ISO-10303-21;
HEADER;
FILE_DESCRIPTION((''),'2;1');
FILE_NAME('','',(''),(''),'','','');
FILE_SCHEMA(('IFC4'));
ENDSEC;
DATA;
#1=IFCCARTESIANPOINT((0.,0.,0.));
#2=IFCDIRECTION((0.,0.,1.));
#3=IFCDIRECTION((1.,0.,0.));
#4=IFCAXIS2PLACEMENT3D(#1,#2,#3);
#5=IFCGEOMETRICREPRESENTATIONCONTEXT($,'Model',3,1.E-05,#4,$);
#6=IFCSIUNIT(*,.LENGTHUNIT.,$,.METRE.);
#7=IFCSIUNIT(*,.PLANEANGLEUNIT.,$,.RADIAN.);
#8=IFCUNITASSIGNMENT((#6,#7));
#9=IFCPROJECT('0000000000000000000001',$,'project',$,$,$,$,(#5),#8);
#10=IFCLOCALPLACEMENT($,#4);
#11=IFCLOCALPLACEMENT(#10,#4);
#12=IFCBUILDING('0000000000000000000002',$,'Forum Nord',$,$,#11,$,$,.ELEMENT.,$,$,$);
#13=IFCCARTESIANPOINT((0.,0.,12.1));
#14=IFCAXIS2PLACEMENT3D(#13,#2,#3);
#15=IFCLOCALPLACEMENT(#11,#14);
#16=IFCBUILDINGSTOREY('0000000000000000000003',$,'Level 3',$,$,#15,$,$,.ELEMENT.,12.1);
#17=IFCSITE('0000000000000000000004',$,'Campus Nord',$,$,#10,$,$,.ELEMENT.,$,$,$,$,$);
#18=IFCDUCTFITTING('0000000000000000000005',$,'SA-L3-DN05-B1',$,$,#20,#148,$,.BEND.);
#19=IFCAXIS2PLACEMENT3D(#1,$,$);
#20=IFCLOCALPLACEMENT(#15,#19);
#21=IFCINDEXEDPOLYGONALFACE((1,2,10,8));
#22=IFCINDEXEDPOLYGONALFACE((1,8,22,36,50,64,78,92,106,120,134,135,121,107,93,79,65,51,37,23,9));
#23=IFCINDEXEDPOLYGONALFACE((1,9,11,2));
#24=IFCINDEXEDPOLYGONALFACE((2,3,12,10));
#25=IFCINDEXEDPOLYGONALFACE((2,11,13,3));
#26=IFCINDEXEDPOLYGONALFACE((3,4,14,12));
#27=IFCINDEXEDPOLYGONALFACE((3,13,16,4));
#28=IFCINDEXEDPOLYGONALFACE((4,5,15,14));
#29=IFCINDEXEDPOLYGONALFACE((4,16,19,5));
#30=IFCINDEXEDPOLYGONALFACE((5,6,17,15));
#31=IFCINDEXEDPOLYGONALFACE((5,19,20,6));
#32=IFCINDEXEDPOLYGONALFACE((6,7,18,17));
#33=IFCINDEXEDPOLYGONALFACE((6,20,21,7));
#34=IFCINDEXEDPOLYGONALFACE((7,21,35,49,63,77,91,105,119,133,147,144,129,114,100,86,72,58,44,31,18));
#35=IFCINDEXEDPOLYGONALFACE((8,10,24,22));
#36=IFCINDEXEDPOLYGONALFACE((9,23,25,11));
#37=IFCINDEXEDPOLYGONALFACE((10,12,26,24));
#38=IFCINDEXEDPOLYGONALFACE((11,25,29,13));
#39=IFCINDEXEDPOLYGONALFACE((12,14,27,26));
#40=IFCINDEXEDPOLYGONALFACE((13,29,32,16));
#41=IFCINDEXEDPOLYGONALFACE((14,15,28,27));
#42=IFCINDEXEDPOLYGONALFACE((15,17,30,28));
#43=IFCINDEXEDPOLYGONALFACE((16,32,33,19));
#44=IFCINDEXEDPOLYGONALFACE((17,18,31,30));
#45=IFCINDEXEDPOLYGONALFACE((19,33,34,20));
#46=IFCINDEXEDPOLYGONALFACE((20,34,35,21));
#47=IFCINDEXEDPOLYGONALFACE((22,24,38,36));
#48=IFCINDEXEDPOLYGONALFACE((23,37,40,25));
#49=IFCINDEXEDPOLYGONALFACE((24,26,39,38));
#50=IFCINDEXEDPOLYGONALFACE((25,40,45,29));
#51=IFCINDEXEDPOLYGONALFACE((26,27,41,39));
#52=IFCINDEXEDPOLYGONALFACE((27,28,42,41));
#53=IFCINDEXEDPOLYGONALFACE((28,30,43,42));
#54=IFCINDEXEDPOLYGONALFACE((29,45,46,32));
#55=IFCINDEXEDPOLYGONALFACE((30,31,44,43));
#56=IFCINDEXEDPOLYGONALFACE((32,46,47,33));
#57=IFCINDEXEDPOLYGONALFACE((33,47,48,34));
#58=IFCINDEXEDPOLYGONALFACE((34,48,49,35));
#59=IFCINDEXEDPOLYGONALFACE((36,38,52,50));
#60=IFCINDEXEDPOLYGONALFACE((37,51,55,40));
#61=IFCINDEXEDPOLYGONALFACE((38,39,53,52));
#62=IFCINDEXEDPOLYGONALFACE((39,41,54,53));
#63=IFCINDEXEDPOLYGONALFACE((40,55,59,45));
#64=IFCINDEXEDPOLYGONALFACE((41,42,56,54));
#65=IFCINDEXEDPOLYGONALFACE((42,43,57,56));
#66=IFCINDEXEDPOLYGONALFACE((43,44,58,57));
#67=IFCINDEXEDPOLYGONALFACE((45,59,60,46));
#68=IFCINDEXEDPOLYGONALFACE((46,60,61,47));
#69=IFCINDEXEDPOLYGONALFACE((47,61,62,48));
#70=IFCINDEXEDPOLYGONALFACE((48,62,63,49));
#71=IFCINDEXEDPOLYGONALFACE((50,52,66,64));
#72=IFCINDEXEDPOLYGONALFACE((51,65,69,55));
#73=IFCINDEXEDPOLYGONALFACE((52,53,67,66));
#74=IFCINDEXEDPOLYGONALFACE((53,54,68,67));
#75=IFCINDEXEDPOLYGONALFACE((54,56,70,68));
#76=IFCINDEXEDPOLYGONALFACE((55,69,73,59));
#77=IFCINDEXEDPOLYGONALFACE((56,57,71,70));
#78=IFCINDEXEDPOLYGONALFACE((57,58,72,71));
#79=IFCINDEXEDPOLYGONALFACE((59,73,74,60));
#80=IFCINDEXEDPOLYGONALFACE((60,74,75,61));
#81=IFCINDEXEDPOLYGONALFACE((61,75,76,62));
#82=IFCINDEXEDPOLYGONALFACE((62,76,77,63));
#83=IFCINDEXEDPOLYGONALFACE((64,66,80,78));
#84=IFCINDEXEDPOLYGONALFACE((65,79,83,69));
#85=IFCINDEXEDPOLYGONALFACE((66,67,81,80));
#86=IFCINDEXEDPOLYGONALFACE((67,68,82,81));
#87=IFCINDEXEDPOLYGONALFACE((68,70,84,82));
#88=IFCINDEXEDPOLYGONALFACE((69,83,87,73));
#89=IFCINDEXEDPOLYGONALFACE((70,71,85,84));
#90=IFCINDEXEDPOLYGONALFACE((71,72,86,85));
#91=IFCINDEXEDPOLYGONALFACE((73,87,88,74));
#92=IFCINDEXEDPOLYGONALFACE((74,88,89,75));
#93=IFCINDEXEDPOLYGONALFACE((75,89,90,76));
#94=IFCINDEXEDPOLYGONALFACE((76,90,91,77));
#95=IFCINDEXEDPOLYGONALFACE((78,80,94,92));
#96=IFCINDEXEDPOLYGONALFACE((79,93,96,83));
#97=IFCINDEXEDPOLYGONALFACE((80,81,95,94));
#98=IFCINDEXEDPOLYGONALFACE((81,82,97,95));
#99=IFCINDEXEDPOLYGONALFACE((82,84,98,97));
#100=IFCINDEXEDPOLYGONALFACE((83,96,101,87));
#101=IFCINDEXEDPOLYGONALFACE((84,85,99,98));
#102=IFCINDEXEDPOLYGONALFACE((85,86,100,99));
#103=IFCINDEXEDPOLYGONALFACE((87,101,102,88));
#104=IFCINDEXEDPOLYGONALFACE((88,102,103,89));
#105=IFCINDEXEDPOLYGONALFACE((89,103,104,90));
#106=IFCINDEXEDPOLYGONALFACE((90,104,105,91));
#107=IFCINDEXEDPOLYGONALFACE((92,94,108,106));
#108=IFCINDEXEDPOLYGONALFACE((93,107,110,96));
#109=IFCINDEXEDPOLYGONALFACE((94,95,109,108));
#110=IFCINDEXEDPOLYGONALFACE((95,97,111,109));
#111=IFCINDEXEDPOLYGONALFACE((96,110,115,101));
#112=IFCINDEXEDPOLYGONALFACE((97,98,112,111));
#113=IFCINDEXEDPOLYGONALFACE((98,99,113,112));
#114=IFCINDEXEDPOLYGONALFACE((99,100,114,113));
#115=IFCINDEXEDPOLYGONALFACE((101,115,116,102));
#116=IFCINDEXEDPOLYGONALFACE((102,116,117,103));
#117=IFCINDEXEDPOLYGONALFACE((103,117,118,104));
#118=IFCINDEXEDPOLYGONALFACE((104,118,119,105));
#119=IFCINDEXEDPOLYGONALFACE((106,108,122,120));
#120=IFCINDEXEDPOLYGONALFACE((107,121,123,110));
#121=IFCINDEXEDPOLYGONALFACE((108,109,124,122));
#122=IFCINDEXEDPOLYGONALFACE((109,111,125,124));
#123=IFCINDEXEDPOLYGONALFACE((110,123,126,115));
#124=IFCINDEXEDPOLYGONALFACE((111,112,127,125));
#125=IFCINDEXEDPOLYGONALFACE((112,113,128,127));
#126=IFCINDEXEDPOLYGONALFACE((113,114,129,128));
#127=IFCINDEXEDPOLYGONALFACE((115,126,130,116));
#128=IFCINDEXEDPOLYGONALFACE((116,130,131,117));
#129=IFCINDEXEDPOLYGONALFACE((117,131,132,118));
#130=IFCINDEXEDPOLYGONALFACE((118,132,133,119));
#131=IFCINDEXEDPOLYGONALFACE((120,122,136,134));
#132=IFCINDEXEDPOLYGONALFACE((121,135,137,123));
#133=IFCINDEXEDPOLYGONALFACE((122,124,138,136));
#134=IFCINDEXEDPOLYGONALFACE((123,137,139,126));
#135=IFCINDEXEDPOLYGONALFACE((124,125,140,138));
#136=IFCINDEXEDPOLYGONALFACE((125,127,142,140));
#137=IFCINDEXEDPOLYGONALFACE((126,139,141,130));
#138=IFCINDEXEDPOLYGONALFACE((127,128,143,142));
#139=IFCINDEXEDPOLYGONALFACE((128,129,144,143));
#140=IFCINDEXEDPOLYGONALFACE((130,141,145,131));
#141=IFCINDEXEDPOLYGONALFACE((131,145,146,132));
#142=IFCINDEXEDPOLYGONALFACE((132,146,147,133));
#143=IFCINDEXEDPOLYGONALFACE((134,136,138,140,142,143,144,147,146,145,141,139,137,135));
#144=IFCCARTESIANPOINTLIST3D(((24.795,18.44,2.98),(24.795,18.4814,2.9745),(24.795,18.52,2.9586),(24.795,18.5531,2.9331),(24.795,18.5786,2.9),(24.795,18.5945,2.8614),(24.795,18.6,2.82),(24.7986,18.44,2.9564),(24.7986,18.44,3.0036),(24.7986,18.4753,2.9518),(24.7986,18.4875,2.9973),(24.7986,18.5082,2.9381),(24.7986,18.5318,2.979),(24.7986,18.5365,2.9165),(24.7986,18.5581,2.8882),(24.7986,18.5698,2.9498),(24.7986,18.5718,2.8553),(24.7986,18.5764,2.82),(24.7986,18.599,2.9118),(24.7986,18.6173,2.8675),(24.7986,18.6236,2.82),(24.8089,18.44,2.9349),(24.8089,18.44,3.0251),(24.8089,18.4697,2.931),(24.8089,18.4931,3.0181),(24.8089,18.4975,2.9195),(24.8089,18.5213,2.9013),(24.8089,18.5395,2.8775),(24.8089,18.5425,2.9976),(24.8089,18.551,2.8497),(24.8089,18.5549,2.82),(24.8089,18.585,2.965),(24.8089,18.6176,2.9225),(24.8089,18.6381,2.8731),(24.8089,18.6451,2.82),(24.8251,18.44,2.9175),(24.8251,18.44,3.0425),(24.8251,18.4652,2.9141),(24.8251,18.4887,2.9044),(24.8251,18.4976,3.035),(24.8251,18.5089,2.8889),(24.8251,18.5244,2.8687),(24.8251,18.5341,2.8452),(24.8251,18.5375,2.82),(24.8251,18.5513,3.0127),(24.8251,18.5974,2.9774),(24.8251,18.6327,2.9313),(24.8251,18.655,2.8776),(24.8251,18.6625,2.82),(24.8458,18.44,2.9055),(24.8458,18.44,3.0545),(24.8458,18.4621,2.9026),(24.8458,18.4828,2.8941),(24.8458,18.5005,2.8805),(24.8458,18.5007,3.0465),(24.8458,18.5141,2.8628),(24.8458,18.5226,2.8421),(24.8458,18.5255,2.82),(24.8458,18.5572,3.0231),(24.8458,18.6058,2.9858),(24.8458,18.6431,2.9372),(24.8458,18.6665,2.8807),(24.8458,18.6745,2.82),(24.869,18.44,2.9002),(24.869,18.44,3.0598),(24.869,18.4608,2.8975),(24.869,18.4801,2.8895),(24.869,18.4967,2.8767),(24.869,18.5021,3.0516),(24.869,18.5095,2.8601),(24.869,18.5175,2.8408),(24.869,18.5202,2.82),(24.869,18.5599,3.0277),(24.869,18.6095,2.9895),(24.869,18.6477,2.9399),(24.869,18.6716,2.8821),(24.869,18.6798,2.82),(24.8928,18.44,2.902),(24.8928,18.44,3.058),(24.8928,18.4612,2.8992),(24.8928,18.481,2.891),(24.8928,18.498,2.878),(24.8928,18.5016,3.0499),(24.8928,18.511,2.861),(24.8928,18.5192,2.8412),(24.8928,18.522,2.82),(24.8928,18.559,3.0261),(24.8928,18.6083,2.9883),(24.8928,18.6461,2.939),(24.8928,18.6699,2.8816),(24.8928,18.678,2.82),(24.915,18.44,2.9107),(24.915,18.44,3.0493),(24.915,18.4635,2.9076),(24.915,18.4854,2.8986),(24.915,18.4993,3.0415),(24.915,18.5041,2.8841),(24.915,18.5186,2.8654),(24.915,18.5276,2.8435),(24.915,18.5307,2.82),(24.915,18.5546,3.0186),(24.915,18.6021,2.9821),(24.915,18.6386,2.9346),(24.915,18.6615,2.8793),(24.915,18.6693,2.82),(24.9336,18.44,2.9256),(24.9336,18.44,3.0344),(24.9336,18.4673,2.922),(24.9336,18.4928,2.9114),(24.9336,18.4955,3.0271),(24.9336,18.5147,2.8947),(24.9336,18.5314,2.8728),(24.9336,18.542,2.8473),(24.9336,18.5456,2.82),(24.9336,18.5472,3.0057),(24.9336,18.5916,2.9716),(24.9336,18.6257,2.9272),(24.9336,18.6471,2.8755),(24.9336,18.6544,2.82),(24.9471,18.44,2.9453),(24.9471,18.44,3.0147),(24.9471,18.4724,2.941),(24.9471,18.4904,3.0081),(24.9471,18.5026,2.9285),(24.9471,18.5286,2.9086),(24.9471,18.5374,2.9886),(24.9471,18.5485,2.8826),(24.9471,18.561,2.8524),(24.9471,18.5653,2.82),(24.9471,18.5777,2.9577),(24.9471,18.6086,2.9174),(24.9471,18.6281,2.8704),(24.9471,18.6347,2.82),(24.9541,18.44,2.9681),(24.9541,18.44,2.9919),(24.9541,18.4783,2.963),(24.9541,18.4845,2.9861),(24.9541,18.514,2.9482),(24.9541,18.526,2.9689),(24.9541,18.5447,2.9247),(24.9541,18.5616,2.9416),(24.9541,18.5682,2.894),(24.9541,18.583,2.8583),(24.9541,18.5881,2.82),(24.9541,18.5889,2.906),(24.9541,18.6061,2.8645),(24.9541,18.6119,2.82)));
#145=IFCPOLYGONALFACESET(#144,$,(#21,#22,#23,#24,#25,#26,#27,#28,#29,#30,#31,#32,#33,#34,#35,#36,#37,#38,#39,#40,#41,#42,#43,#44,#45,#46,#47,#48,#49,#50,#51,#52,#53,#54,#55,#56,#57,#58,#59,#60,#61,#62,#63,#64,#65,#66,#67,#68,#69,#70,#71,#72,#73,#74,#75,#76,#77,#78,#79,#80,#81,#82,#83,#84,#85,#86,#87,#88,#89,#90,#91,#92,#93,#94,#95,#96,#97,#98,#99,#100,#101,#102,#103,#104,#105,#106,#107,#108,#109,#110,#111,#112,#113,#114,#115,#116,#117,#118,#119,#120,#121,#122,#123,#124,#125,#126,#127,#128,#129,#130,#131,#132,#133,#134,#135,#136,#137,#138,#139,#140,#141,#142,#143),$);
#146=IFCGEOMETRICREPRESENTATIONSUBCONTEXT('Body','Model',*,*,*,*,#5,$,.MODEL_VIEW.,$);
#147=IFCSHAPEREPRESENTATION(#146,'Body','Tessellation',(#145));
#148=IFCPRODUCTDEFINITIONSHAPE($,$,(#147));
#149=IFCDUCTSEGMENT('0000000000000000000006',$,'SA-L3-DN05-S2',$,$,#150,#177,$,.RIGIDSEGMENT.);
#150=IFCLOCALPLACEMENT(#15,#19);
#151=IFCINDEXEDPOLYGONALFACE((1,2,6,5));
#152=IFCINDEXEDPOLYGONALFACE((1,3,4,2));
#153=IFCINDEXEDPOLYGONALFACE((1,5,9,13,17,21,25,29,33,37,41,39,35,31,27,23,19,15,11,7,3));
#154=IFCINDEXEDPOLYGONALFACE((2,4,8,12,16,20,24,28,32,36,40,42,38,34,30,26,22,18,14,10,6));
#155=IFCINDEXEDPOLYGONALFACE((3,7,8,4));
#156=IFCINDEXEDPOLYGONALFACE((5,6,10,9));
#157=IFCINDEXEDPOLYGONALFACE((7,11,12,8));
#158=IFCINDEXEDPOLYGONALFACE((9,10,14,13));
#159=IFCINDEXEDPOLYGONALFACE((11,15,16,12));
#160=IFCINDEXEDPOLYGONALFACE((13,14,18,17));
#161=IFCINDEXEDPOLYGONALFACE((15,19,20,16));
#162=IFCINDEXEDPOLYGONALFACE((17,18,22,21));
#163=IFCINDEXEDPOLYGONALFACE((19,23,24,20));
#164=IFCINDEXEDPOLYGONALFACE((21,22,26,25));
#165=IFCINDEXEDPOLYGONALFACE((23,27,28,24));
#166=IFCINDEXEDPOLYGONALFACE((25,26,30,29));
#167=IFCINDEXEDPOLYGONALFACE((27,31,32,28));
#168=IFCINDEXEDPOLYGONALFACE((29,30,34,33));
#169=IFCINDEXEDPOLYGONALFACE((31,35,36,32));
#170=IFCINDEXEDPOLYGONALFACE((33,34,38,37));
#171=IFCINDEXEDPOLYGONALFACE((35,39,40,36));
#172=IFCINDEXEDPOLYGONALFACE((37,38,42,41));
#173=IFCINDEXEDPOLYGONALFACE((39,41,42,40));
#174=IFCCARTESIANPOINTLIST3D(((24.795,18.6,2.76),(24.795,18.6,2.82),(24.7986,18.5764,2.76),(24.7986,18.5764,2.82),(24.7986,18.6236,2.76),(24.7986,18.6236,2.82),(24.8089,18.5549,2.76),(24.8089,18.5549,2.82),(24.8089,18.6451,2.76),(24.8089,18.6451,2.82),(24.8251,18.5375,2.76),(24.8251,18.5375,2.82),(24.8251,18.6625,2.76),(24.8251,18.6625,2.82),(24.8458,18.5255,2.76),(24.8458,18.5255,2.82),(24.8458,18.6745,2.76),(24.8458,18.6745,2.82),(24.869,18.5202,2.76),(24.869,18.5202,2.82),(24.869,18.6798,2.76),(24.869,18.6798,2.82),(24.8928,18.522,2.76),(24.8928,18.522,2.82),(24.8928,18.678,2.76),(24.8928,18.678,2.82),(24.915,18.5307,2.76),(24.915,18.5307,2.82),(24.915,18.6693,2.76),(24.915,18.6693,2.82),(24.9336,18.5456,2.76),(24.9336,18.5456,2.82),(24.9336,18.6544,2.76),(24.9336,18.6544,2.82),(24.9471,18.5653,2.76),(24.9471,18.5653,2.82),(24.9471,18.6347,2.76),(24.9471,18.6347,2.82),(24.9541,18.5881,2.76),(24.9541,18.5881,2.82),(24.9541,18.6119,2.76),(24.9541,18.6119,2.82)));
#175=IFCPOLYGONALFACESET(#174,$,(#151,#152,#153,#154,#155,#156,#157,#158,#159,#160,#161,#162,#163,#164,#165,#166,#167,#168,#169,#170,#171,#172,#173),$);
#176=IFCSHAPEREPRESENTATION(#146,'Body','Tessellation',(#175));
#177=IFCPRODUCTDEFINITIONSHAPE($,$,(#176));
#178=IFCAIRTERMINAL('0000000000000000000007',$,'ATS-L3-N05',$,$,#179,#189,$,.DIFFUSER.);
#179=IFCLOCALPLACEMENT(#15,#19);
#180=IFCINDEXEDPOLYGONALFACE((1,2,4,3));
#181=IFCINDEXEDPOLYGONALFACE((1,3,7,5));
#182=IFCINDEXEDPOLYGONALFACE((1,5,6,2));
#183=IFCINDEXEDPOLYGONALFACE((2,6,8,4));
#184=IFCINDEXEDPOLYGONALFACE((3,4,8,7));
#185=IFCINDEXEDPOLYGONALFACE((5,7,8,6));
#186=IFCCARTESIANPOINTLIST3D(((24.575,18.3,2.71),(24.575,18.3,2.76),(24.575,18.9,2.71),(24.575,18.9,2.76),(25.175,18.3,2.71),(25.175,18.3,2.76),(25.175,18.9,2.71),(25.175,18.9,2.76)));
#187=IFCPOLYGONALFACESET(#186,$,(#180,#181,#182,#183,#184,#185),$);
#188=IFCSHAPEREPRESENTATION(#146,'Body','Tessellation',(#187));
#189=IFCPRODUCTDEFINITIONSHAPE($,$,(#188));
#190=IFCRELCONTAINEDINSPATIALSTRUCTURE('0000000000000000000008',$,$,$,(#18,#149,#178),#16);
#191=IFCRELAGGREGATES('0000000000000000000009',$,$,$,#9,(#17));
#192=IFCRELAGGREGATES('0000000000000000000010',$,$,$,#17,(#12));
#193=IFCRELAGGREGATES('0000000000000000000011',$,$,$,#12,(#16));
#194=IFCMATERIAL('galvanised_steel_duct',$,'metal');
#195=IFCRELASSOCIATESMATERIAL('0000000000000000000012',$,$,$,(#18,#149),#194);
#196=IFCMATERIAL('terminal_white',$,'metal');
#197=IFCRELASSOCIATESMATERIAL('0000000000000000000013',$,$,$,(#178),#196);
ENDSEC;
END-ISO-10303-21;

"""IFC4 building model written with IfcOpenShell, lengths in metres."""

from ifc_helpers import new_model, entity, si_unit, frame, origin_with_axes, origin_2d_with_axis, place, context, subcontext, project, spatial, rectangle, circle, extrude, material, element, save


model = new_model("IFC4")

# Units and contexts
model_context = context("Model", 3, precision=1e-05, world=origin_with_axes())
body_context = subcontext(model_context, "Body", "Model", "MODEL_VIEW")
ifc_project = project(units=[si_unit("LENGTHUNIT", "METRE"), si_unit("PLANEANGLEUNIT", "RADIAN")], contexts=[model_context])

# Site, building, storey
site_placement = place(None, origin_with_axes())
site = spatial("IfcSite", under=ifc_project, at=site_placement, Name="Campus Nord", CompositionType="ELEMENT")
building_placement = place(site_placement, origin_with_axes())
building = spatial("IfcBuilding", under=site, at=building_placement, Name="Forum Nord", CompositionType="ELEMENT")
storey_placement = place(building_placement, frame((0.0, 0.0, 12.1), z_axis=(0.0, 0.0, 1.0), x_axis=(1.0, 0.0, 0.0)))
storey = spatial("IfcBuildingStorey", under=building, at=storey_placement, Name="Level 3", CompositionType="ELEMENT", Elevation=12.1)

# Shared definitions
ifc_material_1 = material(Name="galvanised_steel_duct", Category="metal")

# Shared definitions
ifc_material_2 = material(Name="terminal_white", Category="metal")

# Duct fitting
duct_fitting_1_placement = place(storey_placement, frame((24.875, 18.44, 2.98), z_axis=(0.0, 1.0, 0.0), x_axis=(-1.0, 0.0, 0.0)))
ifc_direction = entity("IfcDirection", [1.0, 0.0, 0.0])
element("IfcDuctFitting", 1, at=duct_fitting_1_placement, inside=storey, material=ifc_material_1, Name="SA-L3-DN05-B1", PredefinedType="BEND", context=body_context, shape_type="SweptSolid", body=[
    entity("IfcRevolvedAreaSolid", entity("IfcCircleProfileDef", "AREA", None, entity("IfcAxis2Placement2D", entity("IfcCartesianPoint", [0.0, 0.0]), entity("IfcDirection", [1.0, 0.0])), 0.08), entity("IfcAxis2Placement3D", entity("IfcCartesianPoint", [0.0, 0.0, 0.0]), entity("IfcDirection", [0.0, 0.0, 1.0]), ifc_direction), entity("IfcAxis1Placement", entity("IfcCartesianPoint", [0.0, -0.16, 0.0]), ifc_direction), 1.5708),
])

# Duct segment
duct_segment_1_placement = place(storey_placement, frame((24.875, 18.6, 2.82), z_axis=(0.0, 0.0, -1.0), x_axis=(-1.0, 0.0, 0.0)))
element("IfcDuctSegment", 2, at=duct_segment_1_placement, inside=storey, material=ifc_material_1, Name="SA-L3-DN05-S2", PredefinedType="RIGIDSEGMENT", context=body_context, shape_type="SweptSolid", body=[
    extrude(circle(Radius=0.08, at=origin_2d_with_axis()), origin_with_axes(), (0.0, 0.0, 1.0), 0.06),
])

# Air terminal
air_terminal_1_placement = place(storey_placement, frame((24.875, 18.6, 2.71), z_axis=(0.0, 0.0, 1.0), x_axis=(1.0, 0.0, 0.0)))
element("IfcAirTerminal", 3, at=air_terminal_1_placement, inside=storey, material=ifc_material_2, Name="ATS-L3-N05", PredefinedType="DIFFUSER", context=body_context, shape_type="SweptSolid", body=[
    extrude(rectangle(XDim=0.6, YDim=0.6, at=origin_2d_with_axis()), origin_with_axes(), (0.0, 0.0, 1.0), 0.05),
])

save(model, "model.ifc")
